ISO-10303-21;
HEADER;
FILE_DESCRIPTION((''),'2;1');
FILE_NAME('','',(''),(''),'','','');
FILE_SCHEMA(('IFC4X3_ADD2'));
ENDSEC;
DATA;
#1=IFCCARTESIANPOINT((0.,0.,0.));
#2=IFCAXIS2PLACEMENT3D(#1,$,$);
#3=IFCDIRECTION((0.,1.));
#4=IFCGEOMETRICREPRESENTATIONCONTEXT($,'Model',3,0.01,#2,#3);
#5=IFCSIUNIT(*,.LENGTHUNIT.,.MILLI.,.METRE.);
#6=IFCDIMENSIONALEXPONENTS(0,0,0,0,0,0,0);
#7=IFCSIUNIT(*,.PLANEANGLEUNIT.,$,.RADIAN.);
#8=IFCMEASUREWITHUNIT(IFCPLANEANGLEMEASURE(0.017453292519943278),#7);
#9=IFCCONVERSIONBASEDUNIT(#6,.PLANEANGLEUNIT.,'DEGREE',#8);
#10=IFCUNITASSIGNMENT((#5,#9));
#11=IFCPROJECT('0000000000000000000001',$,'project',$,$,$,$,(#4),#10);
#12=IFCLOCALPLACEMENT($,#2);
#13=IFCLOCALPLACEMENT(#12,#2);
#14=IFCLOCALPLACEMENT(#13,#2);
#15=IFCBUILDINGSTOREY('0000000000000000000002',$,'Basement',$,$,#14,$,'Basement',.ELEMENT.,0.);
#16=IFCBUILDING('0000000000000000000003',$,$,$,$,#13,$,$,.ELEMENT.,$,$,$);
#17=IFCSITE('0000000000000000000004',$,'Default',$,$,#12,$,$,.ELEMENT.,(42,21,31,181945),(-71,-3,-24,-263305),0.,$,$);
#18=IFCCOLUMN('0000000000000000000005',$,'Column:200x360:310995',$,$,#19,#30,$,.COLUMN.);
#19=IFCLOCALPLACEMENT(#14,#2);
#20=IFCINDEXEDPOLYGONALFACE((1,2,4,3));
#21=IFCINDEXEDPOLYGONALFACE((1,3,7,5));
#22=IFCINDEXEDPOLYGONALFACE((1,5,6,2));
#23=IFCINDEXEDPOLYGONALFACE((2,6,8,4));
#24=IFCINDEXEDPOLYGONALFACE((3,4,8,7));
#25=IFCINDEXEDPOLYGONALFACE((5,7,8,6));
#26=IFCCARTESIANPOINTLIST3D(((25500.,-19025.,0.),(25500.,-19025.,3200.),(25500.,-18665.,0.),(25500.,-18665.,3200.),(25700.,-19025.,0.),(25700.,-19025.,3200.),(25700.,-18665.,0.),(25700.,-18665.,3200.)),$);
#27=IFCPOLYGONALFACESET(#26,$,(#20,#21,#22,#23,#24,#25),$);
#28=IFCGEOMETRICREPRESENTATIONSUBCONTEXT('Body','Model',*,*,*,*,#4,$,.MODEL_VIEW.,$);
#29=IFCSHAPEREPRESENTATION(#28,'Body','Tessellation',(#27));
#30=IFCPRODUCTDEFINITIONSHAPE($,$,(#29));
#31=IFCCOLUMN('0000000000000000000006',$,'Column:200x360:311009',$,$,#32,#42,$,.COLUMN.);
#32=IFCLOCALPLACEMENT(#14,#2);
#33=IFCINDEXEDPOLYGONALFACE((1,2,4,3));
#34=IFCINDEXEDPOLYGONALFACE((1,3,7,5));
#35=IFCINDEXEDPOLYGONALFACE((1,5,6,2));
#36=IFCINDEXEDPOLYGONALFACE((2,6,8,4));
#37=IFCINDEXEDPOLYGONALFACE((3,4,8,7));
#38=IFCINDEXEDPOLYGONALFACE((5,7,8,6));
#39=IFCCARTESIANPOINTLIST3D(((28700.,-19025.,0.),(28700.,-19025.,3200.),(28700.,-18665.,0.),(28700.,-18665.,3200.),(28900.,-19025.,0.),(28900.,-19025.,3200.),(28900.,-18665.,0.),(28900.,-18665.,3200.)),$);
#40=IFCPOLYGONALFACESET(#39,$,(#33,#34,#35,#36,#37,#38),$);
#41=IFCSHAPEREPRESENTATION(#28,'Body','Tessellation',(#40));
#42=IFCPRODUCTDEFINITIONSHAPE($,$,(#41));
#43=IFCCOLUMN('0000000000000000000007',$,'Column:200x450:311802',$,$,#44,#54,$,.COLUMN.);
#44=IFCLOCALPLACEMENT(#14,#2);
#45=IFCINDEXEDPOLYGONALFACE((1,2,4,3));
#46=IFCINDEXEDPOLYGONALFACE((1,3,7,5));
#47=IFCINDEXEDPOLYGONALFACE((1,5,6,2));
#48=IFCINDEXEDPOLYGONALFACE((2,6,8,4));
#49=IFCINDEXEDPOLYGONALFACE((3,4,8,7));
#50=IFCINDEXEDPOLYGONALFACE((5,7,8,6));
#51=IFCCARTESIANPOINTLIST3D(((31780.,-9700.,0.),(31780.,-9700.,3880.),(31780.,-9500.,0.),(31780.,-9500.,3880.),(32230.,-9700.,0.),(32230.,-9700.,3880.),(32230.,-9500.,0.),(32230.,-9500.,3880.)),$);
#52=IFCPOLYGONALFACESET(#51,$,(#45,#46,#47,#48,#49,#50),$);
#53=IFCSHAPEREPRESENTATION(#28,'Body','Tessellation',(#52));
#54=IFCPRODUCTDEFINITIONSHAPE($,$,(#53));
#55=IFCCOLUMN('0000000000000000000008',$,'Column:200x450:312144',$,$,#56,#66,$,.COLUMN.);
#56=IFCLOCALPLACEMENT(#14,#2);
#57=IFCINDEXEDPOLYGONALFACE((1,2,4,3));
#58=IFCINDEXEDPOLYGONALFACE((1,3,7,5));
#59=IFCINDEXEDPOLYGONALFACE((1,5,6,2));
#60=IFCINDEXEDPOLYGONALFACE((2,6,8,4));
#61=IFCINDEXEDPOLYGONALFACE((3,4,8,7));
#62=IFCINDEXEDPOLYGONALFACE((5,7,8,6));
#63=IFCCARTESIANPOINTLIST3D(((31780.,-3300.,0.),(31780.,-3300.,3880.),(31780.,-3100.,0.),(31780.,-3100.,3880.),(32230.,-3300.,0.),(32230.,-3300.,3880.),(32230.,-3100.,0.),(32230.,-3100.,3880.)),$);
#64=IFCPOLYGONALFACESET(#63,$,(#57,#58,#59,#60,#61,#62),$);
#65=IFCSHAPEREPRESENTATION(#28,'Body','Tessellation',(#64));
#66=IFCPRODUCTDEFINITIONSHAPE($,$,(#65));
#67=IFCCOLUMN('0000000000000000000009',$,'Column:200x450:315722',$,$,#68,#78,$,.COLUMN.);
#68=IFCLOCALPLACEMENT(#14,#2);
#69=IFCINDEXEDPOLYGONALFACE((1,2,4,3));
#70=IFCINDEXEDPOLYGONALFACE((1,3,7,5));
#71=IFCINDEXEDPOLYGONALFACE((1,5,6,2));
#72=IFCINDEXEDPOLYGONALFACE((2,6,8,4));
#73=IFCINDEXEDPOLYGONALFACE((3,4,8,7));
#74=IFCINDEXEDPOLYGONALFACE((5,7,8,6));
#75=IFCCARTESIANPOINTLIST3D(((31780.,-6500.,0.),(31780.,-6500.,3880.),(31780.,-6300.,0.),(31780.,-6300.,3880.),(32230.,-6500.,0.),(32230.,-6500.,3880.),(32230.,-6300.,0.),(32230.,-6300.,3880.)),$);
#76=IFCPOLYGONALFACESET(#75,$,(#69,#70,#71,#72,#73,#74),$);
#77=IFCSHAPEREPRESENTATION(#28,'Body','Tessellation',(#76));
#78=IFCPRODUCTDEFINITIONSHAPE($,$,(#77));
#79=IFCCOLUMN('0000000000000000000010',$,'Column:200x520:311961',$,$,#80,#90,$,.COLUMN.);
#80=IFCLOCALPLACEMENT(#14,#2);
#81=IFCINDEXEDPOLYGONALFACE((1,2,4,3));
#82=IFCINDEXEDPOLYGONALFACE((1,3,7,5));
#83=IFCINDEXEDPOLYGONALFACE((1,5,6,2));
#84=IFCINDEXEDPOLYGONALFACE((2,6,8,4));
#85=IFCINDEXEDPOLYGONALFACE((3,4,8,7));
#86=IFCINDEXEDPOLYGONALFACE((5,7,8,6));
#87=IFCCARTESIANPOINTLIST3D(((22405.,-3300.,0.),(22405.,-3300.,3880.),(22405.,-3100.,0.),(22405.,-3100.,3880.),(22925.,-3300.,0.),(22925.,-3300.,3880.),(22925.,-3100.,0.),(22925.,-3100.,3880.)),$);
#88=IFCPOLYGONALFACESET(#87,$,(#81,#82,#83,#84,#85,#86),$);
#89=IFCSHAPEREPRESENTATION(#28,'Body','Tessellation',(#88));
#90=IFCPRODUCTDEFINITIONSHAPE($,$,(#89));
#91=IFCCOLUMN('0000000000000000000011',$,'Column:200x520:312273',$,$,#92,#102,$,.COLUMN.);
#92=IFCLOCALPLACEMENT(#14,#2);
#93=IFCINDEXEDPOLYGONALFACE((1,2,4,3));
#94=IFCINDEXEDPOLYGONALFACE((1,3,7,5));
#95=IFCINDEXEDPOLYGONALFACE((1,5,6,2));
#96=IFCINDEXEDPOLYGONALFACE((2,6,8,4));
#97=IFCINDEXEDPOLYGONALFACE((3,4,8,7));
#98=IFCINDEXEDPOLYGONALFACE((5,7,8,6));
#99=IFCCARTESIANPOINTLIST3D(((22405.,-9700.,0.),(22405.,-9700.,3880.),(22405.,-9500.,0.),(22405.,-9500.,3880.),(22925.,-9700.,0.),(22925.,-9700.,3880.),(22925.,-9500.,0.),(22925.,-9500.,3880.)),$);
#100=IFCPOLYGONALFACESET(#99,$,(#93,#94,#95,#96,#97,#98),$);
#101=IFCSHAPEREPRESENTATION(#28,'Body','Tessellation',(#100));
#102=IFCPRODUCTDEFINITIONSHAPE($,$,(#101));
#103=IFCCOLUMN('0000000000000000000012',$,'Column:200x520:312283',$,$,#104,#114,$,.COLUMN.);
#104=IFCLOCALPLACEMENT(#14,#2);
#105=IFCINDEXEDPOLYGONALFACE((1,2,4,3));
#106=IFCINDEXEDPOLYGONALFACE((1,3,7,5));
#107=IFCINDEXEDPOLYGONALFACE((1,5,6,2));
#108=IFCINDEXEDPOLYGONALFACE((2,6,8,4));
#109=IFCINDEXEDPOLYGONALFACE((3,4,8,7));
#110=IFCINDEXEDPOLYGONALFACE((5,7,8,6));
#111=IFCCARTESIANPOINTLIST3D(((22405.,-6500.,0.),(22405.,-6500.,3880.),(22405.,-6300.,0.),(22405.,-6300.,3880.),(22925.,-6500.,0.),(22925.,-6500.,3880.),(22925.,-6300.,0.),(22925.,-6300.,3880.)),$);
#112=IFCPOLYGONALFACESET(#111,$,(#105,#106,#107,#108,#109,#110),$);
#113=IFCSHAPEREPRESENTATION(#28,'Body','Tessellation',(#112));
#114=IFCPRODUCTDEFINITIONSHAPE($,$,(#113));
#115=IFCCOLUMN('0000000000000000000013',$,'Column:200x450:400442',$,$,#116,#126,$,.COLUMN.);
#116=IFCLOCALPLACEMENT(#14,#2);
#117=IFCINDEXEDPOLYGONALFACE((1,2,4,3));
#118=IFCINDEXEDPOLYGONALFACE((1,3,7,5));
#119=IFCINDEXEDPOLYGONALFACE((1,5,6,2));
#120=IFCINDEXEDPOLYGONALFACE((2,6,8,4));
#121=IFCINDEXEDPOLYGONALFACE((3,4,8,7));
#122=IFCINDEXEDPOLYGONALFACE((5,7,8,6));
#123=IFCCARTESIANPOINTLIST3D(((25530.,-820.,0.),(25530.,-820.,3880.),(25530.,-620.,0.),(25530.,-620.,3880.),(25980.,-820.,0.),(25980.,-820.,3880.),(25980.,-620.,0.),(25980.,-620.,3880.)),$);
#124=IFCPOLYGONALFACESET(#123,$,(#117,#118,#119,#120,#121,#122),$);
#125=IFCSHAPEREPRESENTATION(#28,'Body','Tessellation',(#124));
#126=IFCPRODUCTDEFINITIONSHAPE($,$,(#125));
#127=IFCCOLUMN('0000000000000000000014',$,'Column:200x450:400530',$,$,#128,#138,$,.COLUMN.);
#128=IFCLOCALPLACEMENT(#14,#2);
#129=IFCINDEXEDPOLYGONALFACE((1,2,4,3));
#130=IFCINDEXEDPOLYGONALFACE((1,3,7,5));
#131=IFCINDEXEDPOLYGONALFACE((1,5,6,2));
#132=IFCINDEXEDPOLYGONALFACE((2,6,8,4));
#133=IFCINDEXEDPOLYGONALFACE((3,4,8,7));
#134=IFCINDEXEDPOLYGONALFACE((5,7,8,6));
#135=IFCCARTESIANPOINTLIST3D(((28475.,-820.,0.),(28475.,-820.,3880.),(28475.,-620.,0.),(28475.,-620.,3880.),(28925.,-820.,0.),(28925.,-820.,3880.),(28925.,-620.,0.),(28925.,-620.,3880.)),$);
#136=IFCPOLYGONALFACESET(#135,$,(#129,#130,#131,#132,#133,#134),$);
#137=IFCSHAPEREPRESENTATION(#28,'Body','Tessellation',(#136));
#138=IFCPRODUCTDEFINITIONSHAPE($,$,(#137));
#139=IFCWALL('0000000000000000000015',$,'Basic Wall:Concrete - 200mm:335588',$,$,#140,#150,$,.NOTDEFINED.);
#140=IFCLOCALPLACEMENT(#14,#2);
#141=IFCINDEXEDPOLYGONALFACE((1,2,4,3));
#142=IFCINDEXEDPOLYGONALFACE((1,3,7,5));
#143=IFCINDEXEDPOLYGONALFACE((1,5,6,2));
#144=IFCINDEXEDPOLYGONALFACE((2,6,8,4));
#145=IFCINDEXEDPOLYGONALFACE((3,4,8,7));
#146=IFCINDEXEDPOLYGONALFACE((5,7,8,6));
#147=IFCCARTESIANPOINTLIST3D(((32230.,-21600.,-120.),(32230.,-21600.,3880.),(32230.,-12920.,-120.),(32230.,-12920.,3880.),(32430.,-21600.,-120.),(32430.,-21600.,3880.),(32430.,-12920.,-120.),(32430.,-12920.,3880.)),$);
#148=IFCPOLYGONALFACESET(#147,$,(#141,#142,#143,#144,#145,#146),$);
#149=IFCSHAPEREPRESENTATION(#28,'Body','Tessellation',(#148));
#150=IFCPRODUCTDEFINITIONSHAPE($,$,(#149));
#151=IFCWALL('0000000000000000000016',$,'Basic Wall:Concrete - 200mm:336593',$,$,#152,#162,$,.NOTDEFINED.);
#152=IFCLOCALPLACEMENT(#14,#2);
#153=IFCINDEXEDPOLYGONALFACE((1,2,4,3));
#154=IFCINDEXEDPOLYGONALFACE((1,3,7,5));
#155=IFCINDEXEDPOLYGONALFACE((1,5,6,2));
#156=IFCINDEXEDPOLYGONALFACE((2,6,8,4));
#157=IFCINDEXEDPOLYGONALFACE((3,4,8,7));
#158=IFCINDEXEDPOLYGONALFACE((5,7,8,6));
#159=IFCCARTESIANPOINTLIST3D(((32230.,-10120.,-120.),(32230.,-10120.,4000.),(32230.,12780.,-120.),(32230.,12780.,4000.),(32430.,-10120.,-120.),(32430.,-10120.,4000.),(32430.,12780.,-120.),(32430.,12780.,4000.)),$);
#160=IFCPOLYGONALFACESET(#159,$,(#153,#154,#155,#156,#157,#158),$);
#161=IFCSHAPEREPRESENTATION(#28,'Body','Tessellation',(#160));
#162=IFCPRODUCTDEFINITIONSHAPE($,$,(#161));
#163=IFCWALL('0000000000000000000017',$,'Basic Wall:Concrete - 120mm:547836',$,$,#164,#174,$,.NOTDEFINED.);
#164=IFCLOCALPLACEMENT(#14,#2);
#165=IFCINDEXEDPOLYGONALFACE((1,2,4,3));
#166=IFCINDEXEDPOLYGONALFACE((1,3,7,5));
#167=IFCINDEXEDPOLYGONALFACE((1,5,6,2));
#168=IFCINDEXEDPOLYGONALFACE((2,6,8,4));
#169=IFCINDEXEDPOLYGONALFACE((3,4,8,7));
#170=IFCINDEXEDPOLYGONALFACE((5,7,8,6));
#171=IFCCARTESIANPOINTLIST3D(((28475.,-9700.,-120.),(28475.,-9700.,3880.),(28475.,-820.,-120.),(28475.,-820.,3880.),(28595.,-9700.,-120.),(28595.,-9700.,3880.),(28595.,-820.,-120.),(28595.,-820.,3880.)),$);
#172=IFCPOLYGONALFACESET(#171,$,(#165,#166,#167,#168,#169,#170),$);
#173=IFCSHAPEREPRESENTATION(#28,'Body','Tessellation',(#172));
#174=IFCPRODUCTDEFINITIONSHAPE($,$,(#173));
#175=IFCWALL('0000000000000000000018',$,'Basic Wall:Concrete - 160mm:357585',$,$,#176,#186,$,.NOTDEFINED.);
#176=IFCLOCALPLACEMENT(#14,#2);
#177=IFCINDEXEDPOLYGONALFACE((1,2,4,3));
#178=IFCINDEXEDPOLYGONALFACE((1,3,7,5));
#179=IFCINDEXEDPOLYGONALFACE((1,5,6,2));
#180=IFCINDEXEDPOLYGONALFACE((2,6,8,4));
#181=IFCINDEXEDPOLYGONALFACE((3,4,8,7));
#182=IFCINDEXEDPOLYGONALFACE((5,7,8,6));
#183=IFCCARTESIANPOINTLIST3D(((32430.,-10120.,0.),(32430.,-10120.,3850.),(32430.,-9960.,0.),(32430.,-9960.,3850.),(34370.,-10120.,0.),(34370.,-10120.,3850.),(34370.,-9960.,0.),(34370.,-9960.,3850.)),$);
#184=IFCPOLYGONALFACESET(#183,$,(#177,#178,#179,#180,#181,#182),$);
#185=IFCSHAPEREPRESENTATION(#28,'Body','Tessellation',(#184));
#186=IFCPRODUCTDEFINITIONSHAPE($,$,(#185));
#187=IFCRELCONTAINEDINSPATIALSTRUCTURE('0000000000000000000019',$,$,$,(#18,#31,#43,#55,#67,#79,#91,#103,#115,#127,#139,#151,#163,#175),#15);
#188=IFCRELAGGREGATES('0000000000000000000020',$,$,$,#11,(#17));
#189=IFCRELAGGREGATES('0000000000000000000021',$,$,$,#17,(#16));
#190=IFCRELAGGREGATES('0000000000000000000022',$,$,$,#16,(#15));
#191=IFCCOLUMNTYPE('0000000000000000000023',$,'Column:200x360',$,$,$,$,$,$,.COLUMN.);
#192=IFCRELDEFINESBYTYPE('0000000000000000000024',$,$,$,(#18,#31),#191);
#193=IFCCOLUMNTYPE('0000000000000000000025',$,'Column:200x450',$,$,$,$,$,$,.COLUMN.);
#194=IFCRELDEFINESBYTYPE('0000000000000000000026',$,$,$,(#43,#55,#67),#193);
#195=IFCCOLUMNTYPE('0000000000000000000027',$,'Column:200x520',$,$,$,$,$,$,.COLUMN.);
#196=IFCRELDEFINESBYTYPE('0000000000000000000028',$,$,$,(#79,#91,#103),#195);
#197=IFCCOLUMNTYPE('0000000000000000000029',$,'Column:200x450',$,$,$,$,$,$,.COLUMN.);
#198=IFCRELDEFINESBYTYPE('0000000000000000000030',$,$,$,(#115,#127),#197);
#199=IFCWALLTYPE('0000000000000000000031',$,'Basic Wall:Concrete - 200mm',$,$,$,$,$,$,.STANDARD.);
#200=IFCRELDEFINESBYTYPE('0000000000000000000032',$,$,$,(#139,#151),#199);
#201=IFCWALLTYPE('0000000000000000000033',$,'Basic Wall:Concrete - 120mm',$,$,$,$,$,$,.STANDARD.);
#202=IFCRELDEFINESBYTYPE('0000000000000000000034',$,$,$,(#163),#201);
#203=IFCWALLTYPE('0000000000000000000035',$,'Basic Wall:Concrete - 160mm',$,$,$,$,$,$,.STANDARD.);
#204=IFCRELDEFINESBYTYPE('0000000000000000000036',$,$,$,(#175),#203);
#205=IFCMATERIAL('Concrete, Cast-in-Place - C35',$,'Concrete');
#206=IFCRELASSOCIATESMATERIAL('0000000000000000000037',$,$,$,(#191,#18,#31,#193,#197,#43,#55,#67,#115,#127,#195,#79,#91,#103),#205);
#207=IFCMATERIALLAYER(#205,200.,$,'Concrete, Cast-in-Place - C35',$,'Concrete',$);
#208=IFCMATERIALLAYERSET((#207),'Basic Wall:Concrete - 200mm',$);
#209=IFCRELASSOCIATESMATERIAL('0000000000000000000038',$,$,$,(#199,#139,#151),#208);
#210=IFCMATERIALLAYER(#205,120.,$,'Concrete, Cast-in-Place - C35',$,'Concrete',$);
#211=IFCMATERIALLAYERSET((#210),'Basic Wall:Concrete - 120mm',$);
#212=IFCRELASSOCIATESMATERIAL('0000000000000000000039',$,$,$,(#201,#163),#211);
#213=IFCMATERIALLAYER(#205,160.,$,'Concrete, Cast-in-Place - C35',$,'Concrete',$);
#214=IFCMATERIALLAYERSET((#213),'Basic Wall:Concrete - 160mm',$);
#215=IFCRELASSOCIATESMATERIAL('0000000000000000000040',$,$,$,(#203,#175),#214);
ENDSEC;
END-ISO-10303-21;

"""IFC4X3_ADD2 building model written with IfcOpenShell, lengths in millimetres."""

from ifc_helpers import new_model, entity, si_unit, converted_unit, direction, frame, frame_2d, origin, origin_2d_with_axis, place, context, subcontext, project, spatial, rectangle, extrude, source, transform, mapped, material, layer, layer_set, material_profile, profile_set, profile_usage, type_object, type_shapes, element, save


model = new_model("IFC4X3_ADD2")

# Units and contexts
model_context = context("Model", 3, precision=0.01, world=origin(), true_north=direction((0.0, 1.0)))
body_context = subcontext(model_context, "Body", "Model", "MODEL_VIEW")
ifc_project = project(units=[si_unit("LENGTHUNIT", "METRE", prefix="MILLI"), converted_unit("PLANEANGLEUNIT", "DEGREE", entity("IfcPlaneAngleMeasure", 0.017453292519943278), si_unit("PLANEANGLEUNIT", "RADIAN"), dimensions=[0, 0, 0, 0, 0, 0, 0])], contexts=[model_context])

# Site, building, storey
site_placement = place(None, origin())
site = spatial("IfcSite", under=ifc_project, at=site_placement, Name="Default", CompositionType="ELEMENT", RefLatitude=(42, 21, 31, 181945), RefLongitude=(-71, -3, -24, -263305), RefElevation=0.0)
building_placement = place(site_placement, origin())
building = spatial("IfcBuilding", under=site, at=building_placement, CompositionType="ELEMENT")
storey_placement = place(building_placement, origin())
storey = spatial("IfcBuildingStorey", under=building, at=storey_placement, Name="Basement", LongName="Basement", CompositionType="ELEMENT", Elevation=0.0)

# Columns
ifc_material = material(Name="Concrete, Cast-in-Place - C35", Category="Concrete")
ifc_material_profile_1 = material_profile(ifc_material, rectangle(XDim=200.0, YDim=360.0, at=origin_2d_with_axis()), Name="200x360")
ifc_profile_set_1 = profile_set([ifc_material_profile_1], Name="200x360")
ifc_profile_usage_1 = profile_usage(ifc_profile_set_1)
column_type_1 = type_object("IfcColumnType", Name="Column:200x360", PredefinedType="COLUMN", material=ifc_profile_set_1)
shared_shape_1 = source(origin(), body_context, "Body", "SweptSolid", [
    extrude(rectangle(XDim=200.0, YDim=360.0, at=origin_2d_with_axis()), frame((0.0, 80.0, 0.0), z_axis=(0.0, 0.0, 1.0), x_axis=(-1.0, 0.0, 0.0)), (0.0, 0.0, 1.0), 3200.0),
])
type_shapes(column_type_1, [shared_shape_1])
for number, where, name in (
    (1, (25600.0, -18925.0, 0.0), "Column:200x360:310995"),
    (2, (28800.0, -18925.0, 0.0), "Column:200x360:311009"),
):
    element("IfcColumn", number, at=place(storey_placement, frame(where)), inside=storey, type_object=column_type_1, material=ifc_profile_usage_1, Name=name, PredefinedType="COLUMN", context=body_context, shape_type="MappedRepresentation", body=[
        mapped(shared_shape_1, transform((0.0, 0.0, 0.0), scale=1.0)),
    ])
ifc_material_profile_2 = material_profile(ifc_material, rectangle(XDim=450.0, YDim=200.0, at=origin_2d_with_axis()), Name="200x450")
ifc_profile_set_2 = profile_set([ifc_material_profile_2], Name="200x450")
ifc_profile_usage_2 = profile_usage(ifc_profile_set_2)
column_type_2 = type_object("IfcColumnType", Name="Column:200x450", PredefinedType="COLUMN", material=ifc_profile_set_2)
shared_shape_2 = source(origin(), body_context, "Body", "SweptSolid", [
    extrude(rectangle(XDim=450.0, YDim=200.0, at=origin_2d_with_axis()), frame((-125.0, 0.0, 0.0), z_axis=(0.0, 0.0, 1.0), x_axis=(-1.0, 0.0, 0.0)), (0.0, 0.0, 1.0), 3880.0),
])
type_shapes(column_type_2, [shared_shape_2])
for number, where, name in (
    (3, (32130.0, -9600.0, 0.0), "Column:200x450:311802"),
    (4, (32130.0, -3200.0, 0.0), "Column:200x450:312144"),
    (5, (32130.0, -6400.0, 0.0), "Column:200x450:315722"),
):
    element("IfcColumn", number, at=place(storey_placement, frame(where)), inside=storey, type_object=column_type_2, material=ifc_profile_usage_2, Name=name, PredefinedType="COLUMN", context=body_context, shape_type="MappedRepresentation", body=[
        mapped(shared_shape_2, transform((0.0, 0.0, 0.0), scale=1.0)),
    ])
ifc_material_profile_3 = material_profile(ifc_material, rectangle(XDim=520.0, YDim=200.0, at=origin_2d_with_axis()), Name="200x520")
ifc_profile_set_3 = profile_set([ifc_material_profile_3], Name="200x520")
ifc_profile_usage_3 = profile_usage(ifc_profile_set_3)
column_type_3 = type_object("IfcColumnType", Name="Column:200x520", PredefinedType="COLUMN", material=ifc_profile_set_3)
shared_shape_3 = source(origin(), body_context, "Body", "SweptSolid", [
    extrude(rectangle(XDim=520.0, YDim=200.0, at=origin_2d_with_axis()), frame((-160.0, 0.0, 0.0), z_axis=(0.0, 0.0, 1.0), x_axis=(-1.0, 0.0, 0.0)), (0.0, 0.0, 1.0), 3880.0),
])
type_shapes(column_type_3, [shared_shape_3])
for number, where, name in (
    (6, (22825.0, -3200.0, 0.0), "Column:200x520:311961"),
    (7, (22825.0, -9600.0, 0.0), "Column:200x520:312273"),
    (8, (22825.0, -6400.0, 0.0), "Column:200x520:312283"),
):
    element("IfcColumn", number, at=place(storey_placement, frame(where)), inside=storey, type_object=column_type_3, material=ifc_profile_usage_3, Name=name, PredefinedType="COLUMN", context=body_context, shape_type="MappedRepresentation", body=[
        mapped(shared_shape_3, transform((0.0, 0.0, 0.0), scale=1.0)),
    ])
column_type_4 = type_object("IfcColumnType", Name="Column:200x450", PredefinedType="COLUMN", material=ifc_profile_set_2)
shared_shape_4 = source(origin(), body_context, "Body", "SweptSolid", [
    extrude(rectangle(XDim=450.0, YDim=200.0, at=origin_2d_with_axis()), frame((-125.0, 0.0, 0.0), z_axis=(0.0, 0.0, 1.0), x_axis=(-1.0, 0.0, 0.0)), (0.0, 0.0, 1.0), 3880.0),
])
type_shapes(column_type_4, [shared_shape_4])
for number, where, name in (
    (9, (25880.0, -720.0, 0.0), "Column:200x450:400442"),
    (10, (28825.0, -720.0, 0.0), "Column:200x450:400530"),
):
    element("IfcColumn", number, at=place(storey_placement, frame(where)), inside=storey, type_object=column_type_4, material=ifc_profile_usage_2, Name=name, PredefinedType="COLUMN", context=body_context, shape_type="MappedRepresentation", body=[
        mapped(shared_shape_4, transform((0.0, 0.0, 0.0), scale=1.0)),
    ])

# Walls
ifc_layer_1 = layer(ifc_material, 200.0, Name="Concrete, Cast-in-Place - C35", Category="Concrete")
ifc_layer_set_1 = layer_set([ifc_layer_1], Name="Basic Wall:Concrete - 200mm")
wall_type_1 = type_object("IfcWallType", Name="Basic Wall:Concrete - 200mm", PredefinedType="STANDARD", material=ifc_layer_set_1)
wall_1_placement = place(storey_placement, frame((32330.0, -21600.0, -120.0), z_axis=(0.0, 0.0, 1.0), x_axis=(0.0, 1.0, 0.0)))
element("IfcWall", 11, at=wall_1_placement, inside=storey, type_object=wall_type_1, material=ifc_layer_set_1, Name="Basic Wall:Concrete - 200mm:335588", PredefinedType="NOTDEFINED", context=body_context, shape_type="SweptSolid", body=[
    extrude(rectangle(XDim=8680.0, YDim=200.0, at=frame_2d((4340.0, 0.0), x_axis=(-1.0, 0.0))), origin(), (0.0, 0.0, 1.0), 4000.0),
])
wall_2_placement = place(storey_placement, frame((32330.0, -10120.0, -120.0), z_axis=(0.0, 0.0, 1.0), x_axis=(0.0, 1.0, 0.0)))
element("IfcWall", 12, at=wall_2_placement, inside=storey, type_object=wall_type_1, material=ifc_layer_set_1, Name="Basic Wall:Concrete - 200mm:336593", PredefinedType="NOTDEFINED", context=body_context, shape_type="SweptSolid", body=[
    extrude(rectangle(XDim=22900.0, YDim=200.0, at=frame_2d((11450.0, 0.0), x_axis=(-1.0, 0.0))), origin(), (0.0, 0.0, 1.0), 4120.0),
])
ifc_layer_2 = layer(ifc_material, 120.0, Name="Concrete, Cast-in-Place - C35", Category="Concrete")
ifc_layer_set_2 = layer_set([ifc_layer_2], Name="Basic Wall:Concrete - 120mm")
wall_type_2 = type_object("IfcWallType", Name="Basic Wall:Concrete - 120mm", PredefinedType="STANDARD", material=ifc_layer_set_2)
wall_3_placement = place(storey_placement, frame((28535.0, -820.0, -120.0), z_axis=(0.0, 0.0, 1.0), x_axis=(0.0, -1.0, 0.0)))
element("IfcWall", 13, at=wall_3_placement, inside=storey, type_object=wall_type_2, material=ifc_layer_set_2, Name="Basic Wall:Concrete - 120mm:547836", PredefinedType="NOTDEFINED", context=body_context, shape_type="SweptSolid", body=[
    extrude(rectangle(XDim=8880.0, YDim=120.0, at=frame_2d((4440.0, 0.0), x_axis=(-1.0, 0.0))), origin(), (0.0, 0.0, 1.0), 4000.0),
])
ifc_layer_3 = layer(ifc_material, 160.0, Name="Concrete, Cast-in-Place - C35", Category="Concrete")
ifc_layer_set_3 = layer_set([ifc_layer_3], Name="Basic Wall:Concrete - 160mm")
wall_type_3 = type_object("IfcWallType", Name="Basic Wall:Concrete - 160mm", PredefinedType="STANDARD", material=ifc_layer_set_3)
wall_4_placement = place(storey_placement, frame((32430.0, -10040.0, 0.0)))
element("IfcWall", 14, at=wall_4_placement, inside=storey, type_object=wall_type_3, material=ifc_layer_set_3, Name="Basic Wall:Concrete - 160mm:357585", PredefinedType="NOTDEFINED", context=body_context, shape_type="SweptSolid", body=[
    extrude(rectangle(XDim=1940.0, YDim=160.0, at=frame_2d((970.0, 0.0), x_axis=(-1.0, 0.0))), origin(), (0.0, 0.0, 1.0), 3850.0),
])

save(model, "model.ifc")
